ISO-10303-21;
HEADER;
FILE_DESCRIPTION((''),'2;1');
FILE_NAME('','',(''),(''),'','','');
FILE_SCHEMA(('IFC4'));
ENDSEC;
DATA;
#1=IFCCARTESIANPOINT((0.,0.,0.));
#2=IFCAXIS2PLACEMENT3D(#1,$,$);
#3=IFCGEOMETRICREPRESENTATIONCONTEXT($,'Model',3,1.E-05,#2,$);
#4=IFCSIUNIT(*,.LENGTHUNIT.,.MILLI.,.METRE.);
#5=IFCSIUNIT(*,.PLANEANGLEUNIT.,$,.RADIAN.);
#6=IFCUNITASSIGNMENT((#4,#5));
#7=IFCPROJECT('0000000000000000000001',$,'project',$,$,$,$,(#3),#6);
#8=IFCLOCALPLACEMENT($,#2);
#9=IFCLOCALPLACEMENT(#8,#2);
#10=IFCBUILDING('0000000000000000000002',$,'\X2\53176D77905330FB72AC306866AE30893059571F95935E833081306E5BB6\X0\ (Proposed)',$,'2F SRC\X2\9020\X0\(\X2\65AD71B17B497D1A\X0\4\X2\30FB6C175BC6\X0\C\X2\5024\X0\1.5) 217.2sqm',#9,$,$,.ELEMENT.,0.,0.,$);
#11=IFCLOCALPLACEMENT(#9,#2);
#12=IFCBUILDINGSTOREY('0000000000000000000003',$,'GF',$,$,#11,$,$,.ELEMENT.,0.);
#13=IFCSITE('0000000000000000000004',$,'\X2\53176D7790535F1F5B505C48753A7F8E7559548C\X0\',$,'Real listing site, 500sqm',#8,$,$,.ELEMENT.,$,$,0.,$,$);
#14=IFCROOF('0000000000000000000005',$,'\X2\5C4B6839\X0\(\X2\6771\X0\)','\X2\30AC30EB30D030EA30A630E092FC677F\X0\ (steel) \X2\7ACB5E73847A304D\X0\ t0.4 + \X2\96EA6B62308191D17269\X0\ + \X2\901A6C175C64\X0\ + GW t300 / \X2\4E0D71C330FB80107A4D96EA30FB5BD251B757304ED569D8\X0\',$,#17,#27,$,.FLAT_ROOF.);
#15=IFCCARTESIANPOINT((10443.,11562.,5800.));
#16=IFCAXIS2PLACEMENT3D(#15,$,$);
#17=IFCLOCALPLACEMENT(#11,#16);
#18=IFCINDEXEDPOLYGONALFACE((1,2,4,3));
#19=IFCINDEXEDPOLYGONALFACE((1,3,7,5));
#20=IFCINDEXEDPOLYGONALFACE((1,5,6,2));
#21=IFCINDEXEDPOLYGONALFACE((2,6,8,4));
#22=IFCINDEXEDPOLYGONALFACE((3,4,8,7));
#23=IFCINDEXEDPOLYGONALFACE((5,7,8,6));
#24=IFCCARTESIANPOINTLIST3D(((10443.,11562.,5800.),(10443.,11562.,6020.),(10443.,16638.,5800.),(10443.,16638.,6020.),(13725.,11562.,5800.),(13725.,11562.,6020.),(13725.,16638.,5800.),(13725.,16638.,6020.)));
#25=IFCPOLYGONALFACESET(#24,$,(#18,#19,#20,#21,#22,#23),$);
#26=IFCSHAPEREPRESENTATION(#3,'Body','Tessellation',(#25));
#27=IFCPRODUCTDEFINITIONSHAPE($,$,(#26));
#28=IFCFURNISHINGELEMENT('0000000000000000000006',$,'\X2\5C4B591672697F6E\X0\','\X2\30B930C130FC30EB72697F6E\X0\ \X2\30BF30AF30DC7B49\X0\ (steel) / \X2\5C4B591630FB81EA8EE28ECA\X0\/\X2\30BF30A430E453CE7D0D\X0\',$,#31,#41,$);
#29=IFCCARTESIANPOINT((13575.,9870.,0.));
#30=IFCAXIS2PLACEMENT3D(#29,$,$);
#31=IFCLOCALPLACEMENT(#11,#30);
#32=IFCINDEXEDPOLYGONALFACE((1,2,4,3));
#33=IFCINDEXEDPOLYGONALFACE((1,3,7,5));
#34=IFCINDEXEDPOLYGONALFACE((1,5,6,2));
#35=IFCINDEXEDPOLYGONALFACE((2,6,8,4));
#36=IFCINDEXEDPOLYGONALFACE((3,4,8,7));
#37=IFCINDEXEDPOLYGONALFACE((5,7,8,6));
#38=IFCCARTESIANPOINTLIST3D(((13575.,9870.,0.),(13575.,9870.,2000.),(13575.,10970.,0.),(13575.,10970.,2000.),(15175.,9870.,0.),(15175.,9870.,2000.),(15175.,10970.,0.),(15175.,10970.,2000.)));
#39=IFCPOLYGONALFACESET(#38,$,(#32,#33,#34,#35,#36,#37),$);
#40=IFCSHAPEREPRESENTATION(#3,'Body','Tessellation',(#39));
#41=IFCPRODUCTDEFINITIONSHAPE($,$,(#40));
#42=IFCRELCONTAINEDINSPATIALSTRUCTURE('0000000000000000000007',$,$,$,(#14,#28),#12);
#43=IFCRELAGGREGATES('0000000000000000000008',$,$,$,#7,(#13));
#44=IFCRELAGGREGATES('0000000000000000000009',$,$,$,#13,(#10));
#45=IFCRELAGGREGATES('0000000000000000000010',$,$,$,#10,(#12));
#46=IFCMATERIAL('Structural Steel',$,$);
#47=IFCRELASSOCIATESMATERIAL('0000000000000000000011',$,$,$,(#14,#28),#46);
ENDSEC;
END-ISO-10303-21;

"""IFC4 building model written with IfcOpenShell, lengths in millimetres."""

from ifc_helpers import new_model, si_unit, frame, frame_2d, origin, place, context, project, spatial, rectangle, extrude, material, element, save


model = new_model("IFC4")

# Units and contexts
model_context = context("Model", 3, precision=1e-05, world=origin())
ifc_project = project(units=[si_unit("LENGTHUNIT", "METRE", prefix="MILLI"), si_unit("PLANEANGLEUNIT", "RADIAN")], contexts=[model_context])

# Site, building, storey
site_placement = place(None, origin())
site = spatial("IfcSite", under=ifc_project, at=site_placement, Name="北海道弟子屈町美留和", ObjectType="Real listing site, 500sqm", CompositionType="ELEMENT", RefElevation=0.0)
building_placement = place(site_placement, origin())
building = spatial("IfcBuilding", under=site, at=building_placement, Name="北海道・犬と暮らす土間広めの家 (Proposed)", ObjectType="2F SRC造(断熱等級4・気密C値1.5) 217.2sqm", CompositionType="ELEMENT", ElevationOfRefHeight=0.0, ElevationOfTerrain=0.0)
storey_placement = place(building_placement, origin())
storey = spatial("IfcBuildingStorey", under=building, at=storey_placement, Name="GF", CompositionType="ELEMENT", Elevation=0.0)

# Roof
ifc_material_1 = material(Name="Structural Steel")
for number, where, name in (
    (1, (10443.0, 11562.0, 5800.0), "屋根(東)"),
):
    element("IfcRoof", number, at=place(storey_placement, frame(where)), inside=storey, material=ifc_material_1, Name=name, Description="ガルバリウム鋼板 (steel) 立平葺き t0.4 + 雪止め金物 + 通気層 + GW t300 / 不燃・耐積雪・寒冷地仕様", PredefinedType="FLAT_ROOF", context=model_context, shape_type="SweptSolid", body=[
        extrude(rectangle(XDim=3282.0, YDim=5076.0, at=frame_2d((1641.0, 2538.0))), frame((10443.0, 11562.0, 5800.0)), (0.0, 0.0, 1.0), 220.0),
    ])

# Furnishing element
furnishing_placement = place(storey_placement, frame((13575.0, 9870.0, 0.0)))
element("IfcFurnishingElement", 2, at=furnishing_placement, inside=storey, material=ifc_material_1, Name="屋外物置", Description="スチール物置 タクボ等 (steel) / 屋外・自転車/タイヤ収納", context=model_context, shape_type="SweptSolid", body=[
    extrude(rectangle(XDim=1600.0, YDim=1100.0, at=frame_2d((800.0, 550.0))), frame((13575.0, 9870.0, 0.0)), (0.0, 0.0, 1.0), 2000.0),
])

save(model, "model.ifc")
